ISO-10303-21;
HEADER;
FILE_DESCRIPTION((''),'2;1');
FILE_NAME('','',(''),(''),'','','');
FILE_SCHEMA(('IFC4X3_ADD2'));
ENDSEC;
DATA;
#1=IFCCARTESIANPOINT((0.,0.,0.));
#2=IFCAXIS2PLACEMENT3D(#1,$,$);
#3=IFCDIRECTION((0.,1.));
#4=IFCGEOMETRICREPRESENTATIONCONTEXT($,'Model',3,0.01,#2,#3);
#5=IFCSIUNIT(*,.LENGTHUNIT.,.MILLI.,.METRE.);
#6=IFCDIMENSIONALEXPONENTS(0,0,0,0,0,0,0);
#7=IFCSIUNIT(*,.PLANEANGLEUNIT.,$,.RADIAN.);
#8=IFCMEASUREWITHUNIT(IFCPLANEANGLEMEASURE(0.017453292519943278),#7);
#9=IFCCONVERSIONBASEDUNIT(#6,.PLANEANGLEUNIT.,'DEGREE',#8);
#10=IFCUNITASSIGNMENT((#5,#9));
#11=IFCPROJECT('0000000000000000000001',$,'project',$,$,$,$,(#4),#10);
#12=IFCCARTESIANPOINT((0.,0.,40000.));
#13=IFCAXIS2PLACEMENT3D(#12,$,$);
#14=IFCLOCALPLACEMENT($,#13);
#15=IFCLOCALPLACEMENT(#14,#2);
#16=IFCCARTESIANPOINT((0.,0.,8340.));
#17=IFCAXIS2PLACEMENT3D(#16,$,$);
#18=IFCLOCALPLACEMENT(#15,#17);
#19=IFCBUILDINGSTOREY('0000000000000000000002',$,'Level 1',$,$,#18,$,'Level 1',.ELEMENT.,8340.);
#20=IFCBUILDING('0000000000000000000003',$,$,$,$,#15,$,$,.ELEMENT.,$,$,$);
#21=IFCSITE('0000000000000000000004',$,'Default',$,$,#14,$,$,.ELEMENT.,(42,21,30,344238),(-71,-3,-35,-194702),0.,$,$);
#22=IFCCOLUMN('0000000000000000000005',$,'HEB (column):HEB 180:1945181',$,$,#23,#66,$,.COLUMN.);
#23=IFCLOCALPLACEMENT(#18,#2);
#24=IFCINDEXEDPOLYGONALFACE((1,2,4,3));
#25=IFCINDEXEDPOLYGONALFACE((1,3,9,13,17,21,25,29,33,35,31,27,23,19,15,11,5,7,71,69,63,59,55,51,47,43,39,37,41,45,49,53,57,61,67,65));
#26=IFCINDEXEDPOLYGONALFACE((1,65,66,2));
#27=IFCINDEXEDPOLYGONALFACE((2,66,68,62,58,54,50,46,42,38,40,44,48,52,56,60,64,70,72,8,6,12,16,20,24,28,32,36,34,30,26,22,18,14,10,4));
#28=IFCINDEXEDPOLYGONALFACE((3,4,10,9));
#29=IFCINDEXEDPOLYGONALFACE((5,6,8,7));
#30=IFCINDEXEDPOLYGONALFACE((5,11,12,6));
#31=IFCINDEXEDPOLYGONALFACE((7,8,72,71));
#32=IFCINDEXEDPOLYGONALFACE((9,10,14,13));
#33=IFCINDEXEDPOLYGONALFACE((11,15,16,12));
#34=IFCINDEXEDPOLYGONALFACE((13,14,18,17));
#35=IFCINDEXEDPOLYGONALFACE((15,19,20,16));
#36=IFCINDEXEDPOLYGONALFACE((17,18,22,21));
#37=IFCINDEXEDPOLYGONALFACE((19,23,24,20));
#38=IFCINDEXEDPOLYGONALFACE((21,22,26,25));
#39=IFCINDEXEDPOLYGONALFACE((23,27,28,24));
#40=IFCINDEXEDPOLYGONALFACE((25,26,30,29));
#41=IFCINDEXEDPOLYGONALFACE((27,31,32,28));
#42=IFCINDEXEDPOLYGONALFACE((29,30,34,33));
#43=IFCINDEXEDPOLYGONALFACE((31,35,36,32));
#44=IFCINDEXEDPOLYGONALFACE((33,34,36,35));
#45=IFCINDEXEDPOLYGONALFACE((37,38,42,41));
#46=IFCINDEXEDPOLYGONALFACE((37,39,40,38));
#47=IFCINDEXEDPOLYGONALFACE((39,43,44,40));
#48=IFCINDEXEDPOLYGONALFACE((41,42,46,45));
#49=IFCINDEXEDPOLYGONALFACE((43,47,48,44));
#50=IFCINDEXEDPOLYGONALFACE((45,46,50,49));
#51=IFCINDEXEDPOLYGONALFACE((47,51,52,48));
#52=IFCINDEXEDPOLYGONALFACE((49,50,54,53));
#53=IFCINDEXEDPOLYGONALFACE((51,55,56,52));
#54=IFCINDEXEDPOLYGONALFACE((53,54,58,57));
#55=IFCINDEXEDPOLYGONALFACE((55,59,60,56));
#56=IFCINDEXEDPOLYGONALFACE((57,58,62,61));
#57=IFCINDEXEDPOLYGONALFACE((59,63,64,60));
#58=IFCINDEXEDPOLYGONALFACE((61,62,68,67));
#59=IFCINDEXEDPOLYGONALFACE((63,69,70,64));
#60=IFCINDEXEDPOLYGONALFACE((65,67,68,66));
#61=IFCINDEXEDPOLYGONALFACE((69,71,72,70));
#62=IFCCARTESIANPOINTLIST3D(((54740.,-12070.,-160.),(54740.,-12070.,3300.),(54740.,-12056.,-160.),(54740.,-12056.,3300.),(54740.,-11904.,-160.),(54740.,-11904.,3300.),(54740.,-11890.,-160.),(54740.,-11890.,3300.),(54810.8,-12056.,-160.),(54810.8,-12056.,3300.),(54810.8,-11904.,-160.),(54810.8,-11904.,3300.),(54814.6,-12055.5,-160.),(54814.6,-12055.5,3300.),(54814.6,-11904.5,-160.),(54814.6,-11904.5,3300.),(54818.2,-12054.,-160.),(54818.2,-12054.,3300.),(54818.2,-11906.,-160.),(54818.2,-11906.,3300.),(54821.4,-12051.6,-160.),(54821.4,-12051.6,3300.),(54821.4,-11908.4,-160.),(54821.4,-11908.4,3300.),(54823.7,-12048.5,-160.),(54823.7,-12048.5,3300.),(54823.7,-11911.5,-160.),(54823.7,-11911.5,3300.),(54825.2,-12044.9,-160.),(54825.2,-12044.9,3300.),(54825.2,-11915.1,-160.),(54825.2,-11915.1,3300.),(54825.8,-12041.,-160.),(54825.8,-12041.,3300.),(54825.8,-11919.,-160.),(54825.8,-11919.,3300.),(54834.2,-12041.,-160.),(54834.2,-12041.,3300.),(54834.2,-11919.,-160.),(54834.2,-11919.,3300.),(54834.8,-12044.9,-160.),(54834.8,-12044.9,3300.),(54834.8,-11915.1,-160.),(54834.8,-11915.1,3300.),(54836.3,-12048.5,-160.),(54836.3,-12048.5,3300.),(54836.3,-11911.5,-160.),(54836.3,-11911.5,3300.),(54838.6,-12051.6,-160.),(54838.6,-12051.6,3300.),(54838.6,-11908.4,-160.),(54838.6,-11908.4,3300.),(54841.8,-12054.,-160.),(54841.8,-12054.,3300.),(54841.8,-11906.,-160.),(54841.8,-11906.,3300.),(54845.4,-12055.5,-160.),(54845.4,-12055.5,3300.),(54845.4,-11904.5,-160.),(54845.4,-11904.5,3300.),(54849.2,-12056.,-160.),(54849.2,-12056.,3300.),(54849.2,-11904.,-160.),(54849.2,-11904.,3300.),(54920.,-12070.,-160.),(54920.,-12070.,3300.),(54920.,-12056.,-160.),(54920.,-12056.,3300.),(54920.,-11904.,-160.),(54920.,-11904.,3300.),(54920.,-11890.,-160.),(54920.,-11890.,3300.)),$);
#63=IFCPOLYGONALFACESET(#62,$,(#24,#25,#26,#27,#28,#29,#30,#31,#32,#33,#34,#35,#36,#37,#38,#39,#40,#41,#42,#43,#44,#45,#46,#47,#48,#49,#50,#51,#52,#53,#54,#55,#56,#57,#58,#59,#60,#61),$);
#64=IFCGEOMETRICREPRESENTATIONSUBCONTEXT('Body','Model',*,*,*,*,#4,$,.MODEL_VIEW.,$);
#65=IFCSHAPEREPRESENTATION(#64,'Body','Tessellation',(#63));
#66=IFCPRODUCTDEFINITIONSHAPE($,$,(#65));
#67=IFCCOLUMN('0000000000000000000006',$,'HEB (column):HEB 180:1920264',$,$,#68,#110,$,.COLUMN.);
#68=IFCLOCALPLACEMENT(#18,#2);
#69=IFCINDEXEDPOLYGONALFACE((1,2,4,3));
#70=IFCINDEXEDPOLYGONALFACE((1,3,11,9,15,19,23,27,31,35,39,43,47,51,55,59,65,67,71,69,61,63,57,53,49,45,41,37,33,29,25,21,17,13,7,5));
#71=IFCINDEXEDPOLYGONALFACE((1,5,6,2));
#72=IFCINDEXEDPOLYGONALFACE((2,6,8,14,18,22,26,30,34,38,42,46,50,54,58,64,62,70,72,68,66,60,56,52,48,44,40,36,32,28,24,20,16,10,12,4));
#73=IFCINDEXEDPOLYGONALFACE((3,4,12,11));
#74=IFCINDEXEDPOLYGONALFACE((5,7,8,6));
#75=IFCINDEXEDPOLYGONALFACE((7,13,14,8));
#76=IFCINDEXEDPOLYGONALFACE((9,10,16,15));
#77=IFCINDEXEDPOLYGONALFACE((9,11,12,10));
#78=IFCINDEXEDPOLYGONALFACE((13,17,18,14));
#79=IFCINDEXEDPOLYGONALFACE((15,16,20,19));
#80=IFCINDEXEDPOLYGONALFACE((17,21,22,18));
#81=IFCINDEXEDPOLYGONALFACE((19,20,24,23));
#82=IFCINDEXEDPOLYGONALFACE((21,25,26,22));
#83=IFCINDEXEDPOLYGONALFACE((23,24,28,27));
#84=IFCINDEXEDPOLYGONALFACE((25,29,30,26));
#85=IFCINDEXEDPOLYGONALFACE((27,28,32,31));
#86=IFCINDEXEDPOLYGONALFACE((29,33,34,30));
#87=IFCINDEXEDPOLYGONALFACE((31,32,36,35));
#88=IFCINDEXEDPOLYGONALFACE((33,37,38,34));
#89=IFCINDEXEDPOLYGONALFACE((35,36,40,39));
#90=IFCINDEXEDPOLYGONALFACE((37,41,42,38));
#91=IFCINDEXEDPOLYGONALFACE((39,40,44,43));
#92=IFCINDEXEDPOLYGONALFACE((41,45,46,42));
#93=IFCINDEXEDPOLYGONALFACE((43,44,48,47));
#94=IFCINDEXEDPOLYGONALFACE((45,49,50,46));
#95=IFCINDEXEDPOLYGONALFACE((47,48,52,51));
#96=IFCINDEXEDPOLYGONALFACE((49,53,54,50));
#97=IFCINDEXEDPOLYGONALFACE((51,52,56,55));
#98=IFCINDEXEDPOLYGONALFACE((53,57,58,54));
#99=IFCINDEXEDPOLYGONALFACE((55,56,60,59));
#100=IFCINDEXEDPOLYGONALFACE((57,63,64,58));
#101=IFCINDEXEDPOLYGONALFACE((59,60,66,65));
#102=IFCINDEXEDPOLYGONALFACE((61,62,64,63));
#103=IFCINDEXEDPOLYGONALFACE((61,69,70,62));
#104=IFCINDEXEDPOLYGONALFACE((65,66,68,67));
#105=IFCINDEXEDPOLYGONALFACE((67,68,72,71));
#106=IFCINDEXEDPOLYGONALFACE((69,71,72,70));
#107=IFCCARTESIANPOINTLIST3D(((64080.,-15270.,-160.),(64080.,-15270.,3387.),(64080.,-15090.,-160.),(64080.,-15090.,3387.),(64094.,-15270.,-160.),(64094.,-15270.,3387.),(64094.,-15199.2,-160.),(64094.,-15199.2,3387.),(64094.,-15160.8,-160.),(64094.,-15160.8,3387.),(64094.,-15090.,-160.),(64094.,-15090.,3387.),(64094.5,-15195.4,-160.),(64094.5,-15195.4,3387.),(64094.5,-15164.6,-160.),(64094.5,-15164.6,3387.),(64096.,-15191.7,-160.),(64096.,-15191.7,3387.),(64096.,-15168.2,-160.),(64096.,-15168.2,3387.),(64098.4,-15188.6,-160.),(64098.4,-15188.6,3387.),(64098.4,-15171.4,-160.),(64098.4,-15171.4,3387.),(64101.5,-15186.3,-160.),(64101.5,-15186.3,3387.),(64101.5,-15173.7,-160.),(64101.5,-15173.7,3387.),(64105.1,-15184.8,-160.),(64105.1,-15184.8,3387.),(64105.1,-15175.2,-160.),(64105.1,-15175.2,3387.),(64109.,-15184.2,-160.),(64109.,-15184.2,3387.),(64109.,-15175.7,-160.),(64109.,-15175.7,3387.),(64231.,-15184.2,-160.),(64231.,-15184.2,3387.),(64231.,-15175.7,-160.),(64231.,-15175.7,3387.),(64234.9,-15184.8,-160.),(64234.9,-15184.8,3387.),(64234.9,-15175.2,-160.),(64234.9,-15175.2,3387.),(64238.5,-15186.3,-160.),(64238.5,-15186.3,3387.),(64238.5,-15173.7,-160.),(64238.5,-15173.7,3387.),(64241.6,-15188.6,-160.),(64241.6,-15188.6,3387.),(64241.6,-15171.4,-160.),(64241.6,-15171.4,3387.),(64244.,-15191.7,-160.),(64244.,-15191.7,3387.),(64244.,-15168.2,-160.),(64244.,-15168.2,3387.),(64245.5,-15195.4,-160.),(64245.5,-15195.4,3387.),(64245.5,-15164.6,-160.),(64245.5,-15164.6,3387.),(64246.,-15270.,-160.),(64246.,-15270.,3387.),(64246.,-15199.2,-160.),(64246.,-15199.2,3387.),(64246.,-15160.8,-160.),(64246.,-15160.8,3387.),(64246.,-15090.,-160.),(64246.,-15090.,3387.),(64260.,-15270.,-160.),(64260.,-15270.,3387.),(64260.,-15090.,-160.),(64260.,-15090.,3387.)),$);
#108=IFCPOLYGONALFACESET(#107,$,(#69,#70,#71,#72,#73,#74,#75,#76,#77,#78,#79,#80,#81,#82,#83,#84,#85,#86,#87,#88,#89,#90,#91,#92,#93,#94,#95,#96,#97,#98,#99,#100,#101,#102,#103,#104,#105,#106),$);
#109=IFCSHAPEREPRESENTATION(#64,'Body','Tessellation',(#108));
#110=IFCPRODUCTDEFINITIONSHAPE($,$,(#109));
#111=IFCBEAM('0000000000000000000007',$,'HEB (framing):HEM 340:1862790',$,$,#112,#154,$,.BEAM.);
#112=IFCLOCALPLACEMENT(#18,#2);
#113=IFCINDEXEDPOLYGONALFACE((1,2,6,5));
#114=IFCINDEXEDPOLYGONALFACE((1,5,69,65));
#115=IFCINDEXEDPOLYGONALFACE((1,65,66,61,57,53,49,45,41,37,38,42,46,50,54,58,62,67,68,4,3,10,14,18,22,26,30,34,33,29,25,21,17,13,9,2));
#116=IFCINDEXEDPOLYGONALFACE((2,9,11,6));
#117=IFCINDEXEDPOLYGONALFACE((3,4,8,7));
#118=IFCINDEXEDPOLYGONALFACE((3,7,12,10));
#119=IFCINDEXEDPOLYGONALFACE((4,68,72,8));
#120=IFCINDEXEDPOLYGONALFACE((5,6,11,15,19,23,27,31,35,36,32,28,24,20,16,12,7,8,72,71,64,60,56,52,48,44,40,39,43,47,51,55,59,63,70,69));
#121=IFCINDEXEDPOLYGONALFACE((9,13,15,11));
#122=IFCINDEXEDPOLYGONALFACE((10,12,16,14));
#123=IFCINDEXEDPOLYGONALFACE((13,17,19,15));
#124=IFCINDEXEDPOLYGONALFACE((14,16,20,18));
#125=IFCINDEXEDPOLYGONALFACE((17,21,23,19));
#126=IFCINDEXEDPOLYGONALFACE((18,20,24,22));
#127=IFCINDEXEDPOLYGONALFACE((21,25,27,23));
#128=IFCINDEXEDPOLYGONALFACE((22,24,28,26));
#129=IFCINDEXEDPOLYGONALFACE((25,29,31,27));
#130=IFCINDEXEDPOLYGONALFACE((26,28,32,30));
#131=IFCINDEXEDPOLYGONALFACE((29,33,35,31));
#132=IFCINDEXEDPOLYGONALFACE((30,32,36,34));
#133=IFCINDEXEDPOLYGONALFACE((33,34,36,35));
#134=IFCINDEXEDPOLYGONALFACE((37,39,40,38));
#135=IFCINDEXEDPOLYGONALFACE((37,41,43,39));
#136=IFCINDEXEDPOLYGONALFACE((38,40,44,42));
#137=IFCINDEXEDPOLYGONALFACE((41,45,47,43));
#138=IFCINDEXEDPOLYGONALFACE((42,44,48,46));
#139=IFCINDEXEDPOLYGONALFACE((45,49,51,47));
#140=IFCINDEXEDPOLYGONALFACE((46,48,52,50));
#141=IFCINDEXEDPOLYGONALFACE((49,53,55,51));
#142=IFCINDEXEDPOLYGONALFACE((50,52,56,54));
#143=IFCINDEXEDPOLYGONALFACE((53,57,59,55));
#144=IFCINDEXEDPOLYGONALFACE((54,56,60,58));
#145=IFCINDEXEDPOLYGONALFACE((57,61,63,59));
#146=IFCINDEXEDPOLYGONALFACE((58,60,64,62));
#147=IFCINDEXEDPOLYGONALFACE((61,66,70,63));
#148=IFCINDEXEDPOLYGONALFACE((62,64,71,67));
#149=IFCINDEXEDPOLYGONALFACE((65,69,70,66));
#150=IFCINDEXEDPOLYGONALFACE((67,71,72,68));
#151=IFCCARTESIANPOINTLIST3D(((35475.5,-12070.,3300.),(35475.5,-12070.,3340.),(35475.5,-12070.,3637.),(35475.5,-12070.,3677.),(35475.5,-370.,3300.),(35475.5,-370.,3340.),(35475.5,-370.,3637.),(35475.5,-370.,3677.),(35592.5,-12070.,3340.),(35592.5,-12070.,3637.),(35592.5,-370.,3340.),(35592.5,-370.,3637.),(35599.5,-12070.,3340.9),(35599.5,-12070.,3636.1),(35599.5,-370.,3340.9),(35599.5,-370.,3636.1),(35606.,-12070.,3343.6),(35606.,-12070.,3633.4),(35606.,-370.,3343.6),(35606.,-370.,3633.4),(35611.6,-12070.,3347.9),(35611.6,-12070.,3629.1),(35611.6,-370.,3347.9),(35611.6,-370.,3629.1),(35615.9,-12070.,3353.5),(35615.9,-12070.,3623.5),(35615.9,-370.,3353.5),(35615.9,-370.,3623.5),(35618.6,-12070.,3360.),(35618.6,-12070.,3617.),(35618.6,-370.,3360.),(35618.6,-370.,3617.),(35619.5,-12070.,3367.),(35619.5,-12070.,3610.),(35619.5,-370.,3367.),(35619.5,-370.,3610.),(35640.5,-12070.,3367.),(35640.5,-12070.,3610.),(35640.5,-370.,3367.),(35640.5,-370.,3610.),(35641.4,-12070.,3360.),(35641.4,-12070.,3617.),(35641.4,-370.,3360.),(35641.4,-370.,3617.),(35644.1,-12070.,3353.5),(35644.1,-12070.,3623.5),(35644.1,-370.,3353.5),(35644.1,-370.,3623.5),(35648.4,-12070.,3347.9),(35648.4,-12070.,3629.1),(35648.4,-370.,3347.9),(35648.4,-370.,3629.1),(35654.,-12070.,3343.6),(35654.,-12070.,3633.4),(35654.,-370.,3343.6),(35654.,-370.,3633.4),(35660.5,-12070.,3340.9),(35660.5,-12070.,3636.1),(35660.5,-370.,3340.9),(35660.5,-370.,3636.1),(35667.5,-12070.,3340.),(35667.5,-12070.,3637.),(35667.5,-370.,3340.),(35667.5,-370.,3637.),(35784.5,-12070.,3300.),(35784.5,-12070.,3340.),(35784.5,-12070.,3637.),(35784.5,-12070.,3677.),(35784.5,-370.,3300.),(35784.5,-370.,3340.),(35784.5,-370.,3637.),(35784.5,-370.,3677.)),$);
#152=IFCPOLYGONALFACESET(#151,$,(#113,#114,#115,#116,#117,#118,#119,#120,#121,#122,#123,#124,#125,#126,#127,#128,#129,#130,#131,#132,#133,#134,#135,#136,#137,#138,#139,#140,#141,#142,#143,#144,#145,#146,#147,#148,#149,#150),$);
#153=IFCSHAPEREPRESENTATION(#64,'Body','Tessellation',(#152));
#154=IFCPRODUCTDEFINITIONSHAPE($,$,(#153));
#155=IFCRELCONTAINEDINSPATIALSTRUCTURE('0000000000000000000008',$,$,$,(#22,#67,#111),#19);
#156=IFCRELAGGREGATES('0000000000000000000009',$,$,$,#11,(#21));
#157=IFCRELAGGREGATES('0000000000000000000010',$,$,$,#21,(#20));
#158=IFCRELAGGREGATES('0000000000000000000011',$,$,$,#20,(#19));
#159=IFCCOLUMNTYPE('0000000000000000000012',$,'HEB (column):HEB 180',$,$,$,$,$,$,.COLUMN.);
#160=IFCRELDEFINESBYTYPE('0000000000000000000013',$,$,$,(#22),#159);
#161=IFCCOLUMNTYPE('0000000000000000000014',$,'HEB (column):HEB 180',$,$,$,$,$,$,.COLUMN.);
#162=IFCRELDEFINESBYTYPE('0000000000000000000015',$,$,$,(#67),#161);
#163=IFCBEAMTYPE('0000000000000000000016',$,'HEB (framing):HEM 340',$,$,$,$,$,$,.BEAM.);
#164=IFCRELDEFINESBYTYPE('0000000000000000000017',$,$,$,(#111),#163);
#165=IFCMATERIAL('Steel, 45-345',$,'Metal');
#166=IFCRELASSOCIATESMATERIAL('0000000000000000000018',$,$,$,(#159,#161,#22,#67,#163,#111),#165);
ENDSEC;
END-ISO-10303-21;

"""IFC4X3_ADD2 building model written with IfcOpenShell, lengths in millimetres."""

from ifc_helpers import new_model, entity, si_unit, converted_unit, direction, frame, frame_2d, origin, origin_2d_with_axis, place, context, subcontext, project, spatial, polyline, circle_curve, parameter, trimmed, segment, composite_curve, i_section, outline, extrude, source, transform, mapped, material, material_profile, profile_set, profile_usage, type_object, type_shapes, element, save


model = new_model("IFC4X3_ADD2")

# Units and contexts
model_context = context("Model", 3, precision=0.01, world=origin(), true_north=direction((0.0, 1.0)))
body_context = subcontext(model_context, "Body", "Model", "MODEL_VIEW")
ifc_project = project(units=[si_unit("LENGTHUNIT", "METRE", prefix="MILLI"), converted_unit("PLANEANGLEUNIT", "DEGREE", entity("IfcPlaneAngleMeasure", 0.017453292519943278), si_unit("PLANEANGLEUNIT", "RADIAN"), dimensions=[0, 0, 0, 0, 0, 0, 0])], contexts=[model_context])

# Site, building, storey
site_placement = place(None, frame((0.0, 0.0, 40000.0)))
site = spatial("IfcSite", under=ifc_project, at=site_placement, Name="Default", CompositionType="ELEMENT", RefLatitude=(42, 21, 30, 344238), RefLongitude=(-71, -3, -35, -194702), RefElevation=0.0)
building_placement = place(site_placement, origin())
building = spatial("IfcBuilding", under=site, at=building_placement, CompositionType="ELEMENT")
storey_placement = place(building_placement, frame((0.0, 0.0, 8340.0)))
storey = spatial("IfcBuildingStorey", under=building, at=storey_placement, Name="Level 1", LongName="Level 1", CompositionType="ELEMENT", Elevation=8340.0)

# Columns
ifc_material = material(Name="Steel, 45-345", Category="Metal")
ifc_material_profile_1 = material_profile(ifc_material, i_section(OverallWidth=180.0, OverallDepth=180.0, WebThickness=8.5, FlangeThickness=14.0, FilletRadius=15.0, at=origin_2d_with_axis()), Name="HEB 180")
ifc_profile_set_1 = profile_set([ifc_material_profile_1], Name="HEB 180")
ifc_profile_usage_1 = profile_usage(ifc_profile_set_1)
column_type_1 = type_object("IfcColumnType", Name="HEB (column):HEB 180", PredefinedType="COLUMN", material=ifc_profile_set_1)
shared_shape_1 = source(origin(), body_context, "Body", "SweptSolid", [
    extrude(i_section(OverallWidth=180.0, OverallDepth=180.0, WebThickness=8.5, FlangeThickness=14.0, FilletRadius=15.0, at=origin_2d_with_axis()), frame((0.0, 0.0, 8180.0), z_axis=(0.0, 0.0, 1.0), x_axis=(-1.0, 0.0, 0.0)), (0.0, 0.0, 1.0), 3460.0),
])
type_shapes(column_type_1, [shared_shape_1])
column_1_placement = place(storey_placement, frame((54830.0, -11980.0, -8340.0)))
element("IfcColumn", 1, at=column_1_placement, inside=storey, type_object=column_type_1, material=ifc_profile_usage_1, Name="HEB (column):HEB 180:1945181", PredefinedType="COLUMN", context=body_context, shape_type="MappedRepresentation", body=[
    mapped(shared_shape_1, transform((0.0, 0.0, 0.0), scale=1.0)),
])
column_type_2 = type_object("IfcColumnType", Name="HEB (column):HEB 180", PredefinedType="COLUMN", material=ifc_profile_set_1)
shared_shape_2 = source(origin(), body_context, "Body", "SweptSolid", [
    extrude(i_section(OverallWidth=180.0, OverallDepth=180.0, WebThickness=8.5, FlangeThickness=14.0, FilletRadius=15.0, at=origin_2d_with_axis()), frame((0.0, 0.0, 8180.0), z_axis=(0.0, 0.0, 1.0), x_axis=(-1.0, 0.0, 0.0)), (0.0, 0.0, 1.0), 3547.0),
])
type_shapes(column_type_2, [shared_shape_2])
column_2_placement = place(storey_placement, frame((64170.0, -15180.0, -8340.0), z_axis=(0.0, 0.0, 1.0), x_axis=(0.0, -1.0, 0.0)))
element("IfcColumn", 2, at=column_2_placement, inside=storey, type_object=column_type_2, material=ifc_profile_usage_1, Name="HEB (column):HEB 180:1920264", PredefinedType="COLUMN", context=body_context, shape_type="MappedRepresentation", body=[
    mapped(shared_shape_2, transform((0.0, 0.0, 0.0), scale=1.0)),
])

# Beam
ifc_material_profile_2 = material_profile(ifc_material, outline(composite_curve([segment(polyline([(-154.5, -148.5), (-154.5, -188.5)]), True, "CONTINUOUS"), segment(polyline([(-154.5, -188.5), (154.5, -188.5)]), True, "CONTINUOUS"), segment(polyline([(154.5, -188.5), (154.5, -148.5)]), True, "CONTINUOUS"), segment(polyline([(154.5, -148.5), (37.5, -148.5)]), True, "CONTINUOUS"), segment(trimmed(circle_curve(frame_2d((37.5, -121.5), x_axis=(1.0, 0.0)), 27.0), [parameter(180.0)], [parameter(270.0)], True, "PARAMETER"), False, "CONTINUOUS"), segment(polyline([(10.5, -121.5), (10.5, 121.5)]), True, "CONTINUOUS"), segment(trimmed(circle_curve(frame_2d((37.5, 121.5), x_axis=(1.0, 0.0)), 27.0), [parameter(90.0)], [parameter(180.0)], True, "PARAMETER"), False, "CONTINUOUS"), segment(polyline([(37.5, 148.5), (154.5, 148.5)]), True, "CONTINUOUS"), segment(polyline([(154.5, 148.5), (154.5, 188.5)]), True, "CONTINUOUS"), segment(polyline([(154.5, 188.5), (-154.5, 188.5)]), True, "CONTINUOUS"), segment(polyline([(-154.5, 188.5), (-154.5, 148.5)]), True, "CONTINUOUS"), segment(polyline([(-154.5, 148.5), (-37.5, 148.5)]), True, "CONTINUOUS"), segment(trimmed(circle_curve(frame_2d((-37.5, 121.5), x_axis=(1.0, 0.0)), 27.0), [parameter(360.0)], [parameter(90.0)], True, "PARAMETER"), False, "CONTINUOUS"), segment(polyline([(-10.5, 121.5), (-10.5, -121.5)]), True, "CONTINUOUS"), segment(trimmed(circle_curve(frame_2d((-37.5, -121.5), x_axis=(1.0, 0.0)), 27.0), [parameter(270.0)], [parameter(0.0)], True, "PARAMETER"), False, "CONTINUOUS"), segment(polyline([(-37.5, -148.5), (-154.5, -148.5)]), True, "CONTINUOUS")], self_intersect=False)), Name="HEM 340")
ifc_profile_set_2 = profile_set([ifc_material_profile_2], Name="HEM 340")
ifc_profile_usage_2 = profile_usage(ifc_profile_set_2, cardinal=8)
beam_type_1 = type_object("IfcBeamType", Name="HEB (framing):HEM 340", PredefinedType="BEAM", material=ifc_profile_set_2)
shared_shape_3 = source(origin(), body_context, "Body", "SweptSolid", [
    extrude(outline(composite_curve([segment(polyline([(-154.5, -148.5), (-154.5, -188.5)]), True, "CONTINUOUS"), segment(polyline([(-154.5, -188.5), (154.5, -188.5)]), True, "CONTINUOUS"), segment(polyline([(154.5, -188.5), (154.5, -148.5)]), True, "CONTINUOUS"), segment(polyline([(154.5, -148.5), (37.5, -148.5)]), True, "CONTINUOUS"), segment(trimmed(circle_curve(frame_2d((37.5, -121.5), x_axis=(1.0, 0.0)), 27.0), [parameter(180.0)], [parameter(270.0)], True, "PARAMETER"), False, "CONTINUOUS"), segment(polyline([(10.5, -121.5), (10.5, 121.5)]), True, "CONTINUOUS"), segment(trimmed(circle_curve(frame_2d((37.5, 121.5), x_axis=(1.0, 0.0)), 27.0), [parameter(90.0)], [parameter(180.0)], True, "PARAMETER"), False, "CONTINUOUS"), segment(polyline([(37.5, 148.5), (154.5, 148.5)]), True, "CONTINUOUS"), segment(polyline([(154.5, 148.5), (154.5, 188.5)]), True, "CONTINUOUS"), segment(polyline([(154.5, 188.5), (-154.5, 188.5)]), True, "CONTINUOUS"), segment(polyline([(-154.5, 188.5), (-154.5, 148.5)]), True, "CONTINUOUS"), segment(polyline([(-154.5, 148.5), (-37.5, 148.5)]), True, "CONTINUOUS"), segment(trimmed(circle_curve(frame_2d((-37.5, 121.5), x_axis=(1.0, 0.0)), 27.0), [parameter(360.0)], [parameter(90.0)], True, "PARAMETER"), False, "CONTINUOUS"), segment(polyline([(-10.5, 121.5), (-10.5, -121.5)]), True, "CONTINUOUS"), segment(trimmed(circle_curve(frame_2d((-37.5, -121.5), x_axis=(1.0, 0.0)), 27.0), [parameter(270.0)], [parameter(0.0)], True, "PARAMETER"), False, "CONTINUOUS"), segment(polyline([(-37.5, -148.5), (-154.5, -148.5)]), True, "CONTINUOUS")], self_intersect=False)), frame((-5850.0, 0.0, 0.0), z_axis=(-1.0, 0.0, 0.0), x_axis=(0.0, -1.0, 0.0)), (0.0, 0.0, -1.0), 11700.0),
])
type_shapes(beam_type_1, [shared_shape_3])
for number, where, z_axis, x_axis, name in (
    (3, (35630.0, -6220.0, 3488.5), (0.0, 0.0, 1.0), (0.0, -1.0, 0.0), "HEB (framing):HEM 340:1862790"),
):
    element("IfcBeam", number, at=place(storey_placement, frame(where, z_axis=z_axis, x_axis=x_axis)), inside=storey, type_object=beam_type_1, material=ifc_profile_usage_2, Name=name, PredefinedType="BEAM", context=body_context, shape_type="MappedRepresentation", body=[
        mapped(shared_shape_3, transform((0.0, 0.0, 0.0), scale=1.0)),
    ])

save(model, "model.ifc")
